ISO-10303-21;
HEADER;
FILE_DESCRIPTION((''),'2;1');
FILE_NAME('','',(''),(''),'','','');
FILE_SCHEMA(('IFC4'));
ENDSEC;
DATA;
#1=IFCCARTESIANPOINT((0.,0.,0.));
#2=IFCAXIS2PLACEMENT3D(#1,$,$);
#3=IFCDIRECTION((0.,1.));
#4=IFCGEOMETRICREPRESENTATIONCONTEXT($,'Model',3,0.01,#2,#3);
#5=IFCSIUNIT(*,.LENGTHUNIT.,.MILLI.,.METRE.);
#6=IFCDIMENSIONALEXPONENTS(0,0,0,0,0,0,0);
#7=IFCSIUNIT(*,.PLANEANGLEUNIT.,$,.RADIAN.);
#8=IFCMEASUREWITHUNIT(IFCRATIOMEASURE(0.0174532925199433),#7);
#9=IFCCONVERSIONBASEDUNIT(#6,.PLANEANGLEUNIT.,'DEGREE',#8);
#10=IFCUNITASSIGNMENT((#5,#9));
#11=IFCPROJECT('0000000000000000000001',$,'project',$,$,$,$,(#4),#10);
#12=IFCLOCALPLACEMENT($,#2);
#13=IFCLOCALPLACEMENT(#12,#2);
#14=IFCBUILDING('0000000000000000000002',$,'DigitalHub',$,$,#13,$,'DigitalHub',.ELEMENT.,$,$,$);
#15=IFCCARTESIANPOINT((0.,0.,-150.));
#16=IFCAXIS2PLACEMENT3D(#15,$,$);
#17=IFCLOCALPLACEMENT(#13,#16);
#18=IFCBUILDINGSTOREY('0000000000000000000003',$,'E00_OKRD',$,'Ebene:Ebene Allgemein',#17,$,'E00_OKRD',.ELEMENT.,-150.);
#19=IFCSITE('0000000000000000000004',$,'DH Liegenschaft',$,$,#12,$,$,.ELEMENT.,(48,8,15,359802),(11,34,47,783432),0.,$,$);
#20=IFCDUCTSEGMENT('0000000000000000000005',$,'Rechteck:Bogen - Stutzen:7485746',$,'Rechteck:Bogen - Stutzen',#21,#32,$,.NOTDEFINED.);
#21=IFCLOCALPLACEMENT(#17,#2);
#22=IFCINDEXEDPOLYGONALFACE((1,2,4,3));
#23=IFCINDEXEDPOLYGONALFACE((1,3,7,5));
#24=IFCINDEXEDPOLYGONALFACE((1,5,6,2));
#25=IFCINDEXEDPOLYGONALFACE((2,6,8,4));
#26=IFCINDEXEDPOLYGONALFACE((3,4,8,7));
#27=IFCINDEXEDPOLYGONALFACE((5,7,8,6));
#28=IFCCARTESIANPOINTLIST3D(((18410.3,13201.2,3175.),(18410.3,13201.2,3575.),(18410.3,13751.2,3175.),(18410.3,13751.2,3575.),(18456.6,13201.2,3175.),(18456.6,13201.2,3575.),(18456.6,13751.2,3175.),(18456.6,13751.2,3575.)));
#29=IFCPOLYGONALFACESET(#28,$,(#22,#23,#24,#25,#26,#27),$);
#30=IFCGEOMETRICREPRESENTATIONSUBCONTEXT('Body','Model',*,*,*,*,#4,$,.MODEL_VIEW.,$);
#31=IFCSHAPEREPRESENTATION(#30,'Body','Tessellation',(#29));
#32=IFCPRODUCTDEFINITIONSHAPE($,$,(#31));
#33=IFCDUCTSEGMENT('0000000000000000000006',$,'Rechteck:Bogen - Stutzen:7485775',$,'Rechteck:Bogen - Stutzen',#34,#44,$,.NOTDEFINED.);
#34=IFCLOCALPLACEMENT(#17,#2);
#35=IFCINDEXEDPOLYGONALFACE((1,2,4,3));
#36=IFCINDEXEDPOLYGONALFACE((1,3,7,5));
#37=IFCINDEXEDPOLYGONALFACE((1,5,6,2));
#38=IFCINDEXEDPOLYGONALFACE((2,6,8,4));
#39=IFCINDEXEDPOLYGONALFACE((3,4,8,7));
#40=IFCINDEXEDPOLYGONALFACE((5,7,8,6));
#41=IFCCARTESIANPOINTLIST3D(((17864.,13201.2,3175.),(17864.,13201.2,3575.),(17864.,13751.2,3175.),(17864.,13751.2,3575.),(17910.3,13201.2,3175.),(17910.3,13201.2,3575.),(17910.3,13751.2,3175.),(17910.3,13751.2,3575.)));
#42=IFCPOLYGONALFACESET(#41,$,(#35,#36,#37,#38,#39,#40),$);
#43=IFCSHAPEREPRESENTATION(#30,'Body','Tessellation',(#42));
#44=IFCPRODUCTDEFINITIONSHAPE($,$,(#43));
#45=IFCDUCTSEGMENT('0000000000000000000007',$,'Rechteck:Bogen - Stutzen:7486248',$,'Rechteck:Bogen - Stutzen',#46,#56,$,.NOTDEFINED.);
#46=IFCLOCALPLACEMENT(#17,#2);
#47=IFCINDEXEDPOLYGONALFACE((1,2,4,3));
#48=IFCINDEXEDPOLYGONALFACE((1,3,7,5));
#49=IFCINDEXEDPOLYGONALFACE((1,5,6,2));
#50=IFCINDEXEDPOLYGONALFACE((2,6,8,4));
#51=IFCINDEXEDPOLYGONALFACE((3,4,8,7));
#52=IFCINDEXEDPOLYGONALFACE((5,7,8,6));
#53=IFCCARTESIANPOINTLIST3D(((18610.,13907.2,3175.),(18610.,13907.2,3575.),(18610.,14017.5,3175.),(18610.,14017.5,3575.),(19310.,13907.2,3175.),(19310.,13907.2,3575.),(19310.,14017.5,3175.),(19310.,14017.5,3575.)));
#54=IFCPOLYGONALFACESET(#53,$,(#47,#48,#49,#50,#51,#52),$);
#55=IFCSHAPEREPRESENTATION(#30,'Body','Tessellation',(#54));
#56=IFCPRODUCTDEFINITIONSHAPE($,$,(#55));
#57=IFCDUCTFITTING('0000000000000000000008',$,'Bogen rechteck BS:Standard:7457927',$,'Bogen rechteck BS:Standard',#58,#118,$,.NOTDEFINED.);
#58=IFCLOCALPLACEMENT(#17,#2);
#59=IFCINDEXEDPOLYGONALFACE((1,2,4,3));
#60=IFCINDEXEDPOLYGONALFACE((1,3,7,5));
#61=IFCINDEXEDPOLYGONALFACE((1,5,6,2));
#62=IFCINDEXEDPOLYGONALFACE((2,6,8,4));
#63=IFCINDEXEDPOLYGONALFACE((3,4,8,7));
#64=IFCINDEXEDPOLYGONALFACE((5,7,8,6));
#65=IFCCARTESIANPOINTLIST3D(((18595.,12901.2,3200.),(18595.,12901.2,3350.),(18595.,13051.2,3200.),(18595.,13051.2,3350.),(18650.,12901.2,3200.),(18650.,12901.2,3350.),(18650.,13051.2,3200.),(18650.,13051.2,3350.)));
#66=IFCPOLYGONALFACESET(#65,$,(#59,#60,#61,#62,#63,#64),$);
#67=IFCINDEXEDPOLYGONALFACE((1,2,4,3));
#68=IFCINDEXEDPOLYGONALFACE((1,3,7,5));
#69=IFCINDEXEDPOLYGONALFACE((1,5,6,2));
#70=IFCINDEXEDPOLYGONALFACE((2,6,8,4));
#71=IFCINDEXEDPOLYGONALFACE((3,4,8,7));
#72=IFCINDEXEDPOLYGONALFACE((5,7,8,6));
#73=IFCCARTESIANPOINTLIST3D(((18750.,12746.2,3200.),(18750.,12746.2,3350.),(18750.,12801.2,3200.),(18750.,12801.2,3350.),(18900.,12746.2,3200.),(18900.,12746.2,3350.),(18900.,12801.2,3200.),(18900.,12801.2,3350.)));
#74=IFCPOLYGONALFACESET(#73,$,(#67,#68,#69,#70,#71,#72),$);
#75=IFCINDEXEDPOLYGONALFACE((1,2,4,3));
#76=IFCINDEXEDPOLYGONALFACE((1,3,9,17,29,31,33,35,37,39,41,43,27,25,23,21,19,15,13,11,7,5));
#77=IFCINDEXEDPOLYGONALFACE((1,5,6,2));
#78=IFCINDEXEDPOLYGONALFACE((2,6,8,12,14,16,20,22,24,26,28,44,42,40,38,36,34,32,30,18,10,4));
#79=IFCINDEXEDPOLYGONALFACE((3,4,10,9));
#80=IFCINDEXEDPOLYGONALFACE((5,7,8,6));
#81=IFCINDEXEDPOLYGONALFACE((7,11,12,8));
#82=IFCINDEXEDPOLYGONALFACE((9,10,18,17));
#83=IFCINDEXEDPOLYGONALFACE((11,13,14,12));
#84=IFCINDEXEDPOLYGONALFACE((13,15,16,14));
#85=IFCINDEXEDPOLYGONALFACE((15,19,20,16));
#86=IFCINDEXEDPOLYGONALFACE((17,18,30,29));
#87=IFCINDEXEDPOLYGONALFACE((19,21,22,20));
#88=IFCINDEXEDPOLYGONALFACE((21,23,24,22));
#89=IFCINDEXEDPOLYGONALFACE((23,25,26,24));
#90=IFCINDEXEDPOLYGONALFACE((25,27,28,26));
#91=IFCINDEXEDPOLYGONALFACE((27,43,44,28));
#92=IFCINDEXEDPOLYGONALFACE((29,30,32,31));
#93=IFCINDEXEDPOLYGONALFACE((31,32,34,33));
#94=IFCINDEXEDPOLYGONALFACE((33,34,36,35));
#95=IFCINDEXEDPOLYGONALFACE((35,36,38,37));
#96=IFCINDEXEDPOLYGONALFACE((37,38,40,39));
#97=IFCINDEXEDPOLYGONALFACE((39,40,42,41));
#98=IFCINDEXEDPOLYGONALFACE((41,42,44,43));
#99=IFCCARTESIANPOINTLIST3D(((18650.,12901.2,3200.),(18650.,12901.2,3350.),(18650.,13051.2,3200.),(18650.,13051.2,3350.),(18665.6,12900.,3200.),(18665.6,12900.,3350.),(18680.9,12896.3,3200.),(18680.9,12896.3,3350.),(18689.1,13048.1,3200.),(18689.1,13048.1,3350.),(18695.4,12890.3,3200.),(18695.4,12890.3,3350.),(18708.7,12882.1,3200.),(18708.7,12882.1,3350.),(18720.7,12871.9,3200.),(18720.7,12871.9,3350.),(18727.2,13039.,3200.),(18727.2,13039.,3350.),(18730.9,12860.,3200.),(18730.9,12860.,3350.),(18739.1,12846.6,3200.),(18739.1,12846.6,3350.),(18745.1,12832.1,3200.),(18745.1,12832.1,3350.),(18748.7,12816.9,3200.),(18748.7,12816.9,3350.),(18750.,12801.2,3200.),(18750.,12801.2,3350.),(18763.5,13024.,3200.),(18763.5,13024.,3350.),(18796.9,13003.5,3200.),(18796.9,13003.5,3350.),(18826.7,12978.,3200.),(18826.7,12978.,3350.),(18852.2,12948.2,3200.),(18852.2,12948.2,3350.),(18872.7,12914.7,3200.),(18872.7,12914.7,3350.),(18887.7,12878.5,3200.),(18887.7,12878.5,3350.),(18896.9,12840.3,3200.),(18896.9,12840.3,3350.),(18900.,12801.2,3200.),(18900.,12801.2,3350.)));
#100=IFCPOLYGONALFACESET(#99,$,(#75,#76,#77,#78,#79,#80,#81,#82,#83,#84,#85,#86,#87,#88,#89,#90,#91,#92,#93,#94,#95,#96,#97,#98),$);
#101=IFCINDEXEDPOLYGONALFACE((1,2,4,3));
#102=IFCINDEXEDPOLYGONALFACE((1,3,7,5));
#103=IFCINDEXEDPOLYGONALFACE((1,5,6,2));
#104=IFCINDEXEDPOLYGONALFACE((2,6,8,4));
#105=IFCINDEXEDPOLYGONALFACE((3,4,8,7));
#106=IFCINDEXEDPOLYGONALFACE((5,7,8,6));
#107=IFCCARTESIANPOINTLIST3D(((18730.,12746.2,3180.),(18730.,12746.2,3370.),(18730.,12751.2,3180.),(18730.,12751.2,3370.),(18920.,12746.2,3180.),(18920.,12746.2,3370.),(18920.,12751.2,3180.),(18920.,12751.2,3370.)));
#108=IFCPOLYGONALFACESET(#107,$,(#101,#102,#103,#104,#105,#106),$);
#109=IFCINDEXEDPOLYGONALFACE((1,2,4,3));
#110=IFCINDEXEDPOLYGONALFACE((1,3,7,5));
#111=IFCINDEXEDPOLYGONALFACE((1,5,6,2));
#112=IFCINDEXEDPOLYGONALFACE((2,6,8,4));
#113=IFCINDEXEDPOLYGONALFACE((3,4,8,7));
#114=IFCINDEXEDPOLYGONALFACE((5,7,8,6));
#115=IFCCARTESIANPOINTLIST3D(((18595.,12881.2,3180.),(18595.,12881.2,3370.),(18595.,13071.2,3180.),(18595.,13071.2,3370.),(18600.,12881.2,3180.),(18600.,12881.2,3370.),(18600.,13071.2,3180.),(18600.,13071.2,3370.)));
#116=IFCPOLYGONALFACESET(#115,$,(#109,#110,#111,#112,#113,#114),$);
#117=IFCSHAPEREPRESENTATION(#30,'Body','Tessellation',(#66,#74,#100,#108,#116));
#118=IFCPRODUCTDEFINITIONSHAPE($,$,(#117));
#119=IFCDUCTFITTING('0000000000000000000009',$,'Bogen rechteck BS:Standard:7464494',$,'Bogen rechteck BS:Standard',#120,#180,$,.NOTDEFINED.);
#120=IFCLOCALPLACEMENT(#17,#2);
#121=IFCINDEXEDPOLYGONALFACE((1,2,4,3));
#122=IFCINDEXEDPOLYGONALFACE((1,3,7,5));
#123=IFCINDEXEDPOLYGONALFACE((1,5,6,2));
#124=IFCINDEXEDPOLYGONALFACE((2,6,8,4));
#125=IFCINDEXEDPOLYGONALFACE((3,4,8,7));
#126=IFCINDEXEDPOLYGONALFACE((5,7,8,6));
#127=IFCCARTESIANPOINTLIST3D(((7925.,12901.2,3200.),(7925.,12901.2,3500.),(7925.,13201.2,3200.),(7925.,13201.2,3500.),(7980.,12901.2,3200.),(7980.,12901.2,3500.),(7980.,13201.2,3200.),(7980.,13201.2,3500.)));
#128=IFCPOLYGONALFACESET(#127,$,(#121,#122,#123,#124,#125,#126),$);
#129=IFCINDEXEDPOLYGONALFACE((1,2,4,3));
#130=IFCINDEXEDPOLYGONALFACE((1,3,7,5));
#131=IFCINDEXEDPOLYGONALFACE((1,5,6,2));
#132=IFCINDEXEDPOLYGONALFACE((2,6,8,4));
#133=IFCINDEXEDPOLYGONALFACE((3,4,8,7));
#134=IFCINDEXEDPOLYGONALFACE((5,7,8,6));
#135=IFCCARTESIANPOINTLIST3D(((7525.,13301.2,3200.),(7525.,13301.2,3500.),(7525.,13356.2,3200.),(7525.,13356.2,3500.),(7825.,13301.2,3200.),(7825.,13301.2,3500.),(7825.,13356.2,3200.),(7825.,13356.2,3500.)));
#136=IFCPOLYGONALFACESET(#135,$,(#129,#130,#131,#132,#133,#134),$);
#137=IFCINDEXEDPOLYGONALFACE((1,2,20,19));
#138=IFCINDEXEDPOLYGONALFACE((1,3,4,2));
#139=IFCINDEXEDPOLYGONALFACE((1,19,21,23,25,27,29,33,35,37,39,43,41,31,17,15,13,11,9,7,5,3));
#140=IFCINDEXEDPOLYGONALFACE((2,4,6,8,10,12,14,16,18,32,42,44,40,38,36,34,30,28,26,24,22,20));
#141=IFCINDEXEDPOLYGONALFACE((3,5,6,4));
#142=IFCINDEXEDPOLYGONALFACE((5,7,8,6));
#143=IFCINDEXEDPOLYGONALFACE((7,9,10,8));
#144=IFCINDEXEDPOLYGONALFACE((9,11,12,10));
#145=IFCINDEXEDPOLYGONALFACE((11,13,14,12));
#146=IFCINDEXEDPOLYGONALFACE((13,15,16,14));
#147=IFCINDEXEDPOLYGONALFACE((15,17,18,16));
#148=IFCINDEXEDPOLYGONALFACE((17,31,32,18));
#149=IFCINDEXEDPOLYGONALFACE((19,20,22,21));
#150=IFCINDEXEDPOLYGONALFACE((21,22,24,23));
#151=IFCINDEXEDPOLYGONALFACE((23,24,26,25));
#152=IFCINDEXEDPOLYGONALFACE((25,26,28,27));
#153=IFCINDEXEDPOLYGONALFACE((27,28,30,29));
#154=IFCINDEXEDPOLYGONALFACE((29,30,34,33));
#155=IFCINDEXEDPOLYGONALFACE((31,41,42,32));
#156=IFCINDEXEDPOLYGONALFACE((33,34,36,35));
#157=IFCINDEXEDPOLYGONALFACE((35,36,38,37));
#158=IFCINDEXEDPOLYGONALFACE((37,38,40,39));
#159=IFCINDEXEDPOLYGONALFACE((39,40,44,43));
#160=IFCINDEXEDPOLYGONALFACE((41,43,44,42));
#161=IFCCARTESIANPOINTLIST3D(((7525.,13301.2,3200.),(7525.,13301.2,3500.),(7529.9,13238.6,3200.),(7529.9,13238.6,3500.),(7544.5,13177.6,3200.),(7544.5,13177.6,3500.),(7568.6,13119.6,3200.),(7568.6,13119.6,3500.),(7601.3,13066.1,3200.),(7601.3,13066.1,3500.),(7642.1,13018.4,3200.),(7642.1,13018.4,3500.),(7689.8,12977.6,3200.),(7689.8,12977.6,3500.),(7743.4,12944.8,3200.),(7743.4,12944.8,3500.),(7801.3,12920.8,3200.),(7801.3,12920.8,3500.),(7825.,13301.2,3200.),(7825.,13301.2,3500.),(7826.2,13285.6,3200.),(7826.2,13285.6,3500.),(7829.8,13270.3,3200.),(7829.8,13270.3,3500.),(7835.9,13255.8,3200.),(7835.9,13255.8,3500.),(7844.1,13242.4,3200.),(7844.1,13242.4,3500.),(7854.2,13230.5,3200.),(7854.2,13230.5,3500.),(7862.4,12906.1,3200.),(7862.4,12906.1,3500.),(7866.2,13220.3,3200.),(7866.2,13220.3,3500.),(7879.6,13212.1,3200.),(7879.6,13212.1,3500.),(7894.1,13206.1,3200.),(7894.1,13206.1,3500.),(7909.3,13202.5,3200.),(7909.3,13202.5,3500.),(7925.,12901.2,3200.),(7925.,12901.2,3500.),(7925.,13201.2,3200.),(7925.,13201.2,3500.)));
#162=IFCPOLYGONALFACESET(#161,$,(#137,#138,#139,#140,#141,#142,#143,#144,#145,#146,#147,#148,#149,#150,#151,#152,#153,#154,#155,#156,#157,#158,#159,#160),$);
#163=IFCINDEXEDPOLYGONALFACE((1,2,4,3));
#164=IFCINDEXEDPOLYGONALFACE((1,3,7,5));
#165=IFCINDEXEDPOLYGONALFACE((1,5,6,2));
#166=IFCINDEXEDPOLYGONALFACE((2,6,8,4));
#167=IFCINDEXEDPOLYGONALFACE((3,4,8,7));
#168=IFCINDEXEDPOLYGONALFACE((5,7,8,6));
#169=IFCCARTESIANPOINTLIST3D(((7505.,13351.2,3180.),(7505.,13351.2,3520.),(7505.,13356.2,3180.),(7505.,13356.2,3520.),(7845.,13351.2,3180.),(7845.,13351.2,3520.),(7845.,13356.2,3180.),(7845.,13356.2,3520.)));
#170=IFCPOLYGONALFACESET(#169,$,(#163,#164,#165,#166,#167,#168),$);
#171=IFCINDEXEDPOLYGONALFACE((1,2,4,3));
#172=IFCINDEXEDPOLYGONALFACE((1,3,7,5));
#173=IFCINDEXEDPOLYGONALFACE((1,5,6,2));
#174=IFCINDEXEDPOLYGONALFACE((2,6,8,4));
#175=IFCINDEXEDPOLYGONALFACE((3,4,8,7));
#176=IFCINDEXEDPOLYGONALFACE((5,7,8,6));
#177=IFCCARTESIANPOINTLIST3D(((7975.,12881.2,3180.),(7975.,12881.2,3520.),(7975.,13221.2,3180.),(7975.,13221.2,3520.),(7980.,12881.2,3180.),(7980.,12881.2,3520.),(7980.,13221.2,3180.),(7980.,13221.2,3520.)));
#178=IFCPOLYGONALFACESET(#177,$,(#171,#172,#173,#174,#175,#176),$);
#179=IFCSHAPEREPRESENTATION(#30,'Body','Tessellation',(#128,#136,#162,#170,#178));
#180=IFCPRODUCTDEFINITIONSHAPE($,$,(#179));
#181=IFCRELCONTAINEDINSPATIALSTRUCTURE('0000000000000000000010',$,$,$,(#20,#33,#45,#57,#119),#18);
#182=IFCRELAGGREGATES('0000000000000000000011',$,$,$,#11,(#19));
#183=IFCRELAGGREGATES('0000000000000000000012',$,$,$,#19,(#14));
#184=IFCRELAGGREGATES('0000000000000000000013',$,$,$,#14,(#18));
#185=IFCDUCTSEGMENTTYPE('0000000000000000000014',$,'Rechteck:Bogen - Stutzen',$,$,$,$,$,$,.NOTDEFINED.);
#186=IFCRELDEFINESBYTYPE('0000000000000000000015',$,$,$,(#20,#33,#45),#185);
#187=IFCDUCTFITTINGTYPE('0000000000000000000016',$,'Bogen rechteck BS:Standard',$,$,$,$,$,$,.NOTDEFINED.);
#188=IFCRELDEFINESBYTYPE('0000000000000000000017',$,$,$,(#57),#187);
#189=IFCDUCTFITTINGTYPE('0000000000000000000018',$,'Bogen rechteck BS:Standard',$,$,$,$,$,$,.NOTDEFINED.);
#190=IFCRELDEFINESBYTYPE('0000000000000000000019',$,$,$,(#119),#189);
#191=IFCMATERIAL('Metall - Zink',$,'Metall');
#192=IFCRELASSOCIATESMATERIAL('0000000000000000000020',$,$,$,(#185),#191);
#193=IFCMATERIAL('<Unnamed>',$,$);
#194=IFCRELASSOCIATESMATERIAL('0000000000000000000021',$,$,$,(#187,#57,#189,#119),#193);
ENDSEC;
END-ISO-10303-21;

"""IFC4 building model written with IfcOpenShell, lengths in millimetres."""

from ifc_helpers import new_model, entity, si_unit, converted_unit, direction, frame, origin, place, context, subcontext, project, spatial, indexed_curve, outline, extrude, source, transform, mapped, material, type_object, type_shapes, element, save


model = new_model("IFC4")

# Units and contexts
model_context = context("Model", 3, precision=0.01, world=origin(), true_north=direction((0.0, 1.0)))
body_context = subcontext(model_context, "Body", "Model", "MODEL_VIEW")
ifc_project = project(units=[si_unit("LENGTHUNIT", "METRE", prefix="MILLI"), converted_unit("PLANEANGLEUNIT", "DEGREE", entity("IfcRatioMeasure", 0.0174532925199433), si_unit("PLANEANGLEUNIT", "RADIAN"), dimensions=[0, 0, 0, 0, 0, 0, 0])], contexts=[model_context])

# Site, building, storey
site_placement = place(None, origin())
site = spatial("IfcSite", under=ifc_project, at=site_placement, Name="DH Liegenschaft", CompositionType="ELEMENT", RefLatitude=(48, 8, 15, 359802), RefLongitude=(11, 34, 47, 783432), RefElevation=0.0)
building_placement = place(site_placement, origin())
building = spatial("IfcBuilding", under=site, at=building_placement, Name="DigitalHub", LongName="DigitalHub", CompositionType="ELEMENT")
storey_placement = place(building_placement, frame((0.0, 0.0, -150.0)))
storey = spatial("IfcBuildingStorey", under=building, at=storey_placement, Name="E00_OKRD", ObjectType="Ebene:Ebene Allgemein", LongName="E00_OKRD", CompositionType="ELEMENT", Elevation=-150.0)

# Duct segments
ifc_material_1 = material(Name="Metall - Zink", Category="Metall")
duct_segment_type = type_object("IfcDuctSegmentType", Name="Rechteck:Bogen - Stutzen", PredefinedType="NOTDEFINED", material=ifc_material_1)
duct_segment_1_placement = place(storey_placement, frame((18410.3, 13201.2, 3175.0)))
element("IfcDuctSegment", 1, at=duct_segment_1_placement, inside=storey, type_object=duct_segment_type, Name="Rechteck:Bogen - Stutzen:7485746", ObjectType="Rechteck:Bogen - Stutzen", PredefinedType="NOTDEFINED", context=body_context, shape_type="SweptSolid", body=[
    extrude(outline(indexed_curve([(-23.1, -275.0), (23.1, -275.0), (23.1, 275.0), (-23.1, 275.0), (-23.1, -275.0)], self_intersect=False)), frame((23.1, 275.0, 0.0)), (0.0, 0.0, 1.0), 400.0),
])
duct_segment_2_placement = place(storey_placement, frame((17864.0, 13201.2, 3175.0)))
element("IfcDuctSegment", 2, at=duct_segment_2_placement, inside=storey, type_object=duct_segment_type, Name="Rechteck:Bogen - Stutzen:7485775", ObjectType="Rechteck:Bogen - Stutzen", PredefinedType="NOTDEFINED", context=body_context, shape_type="SweptSolid", body=[
    extrude(outline(indexed_curve([(-23.1, -275.0), (23.1, -275.0), (23.1, 275.0), (-23.1, 275.0), (-23.1, -275.0)], self_intersect=False)), frame((23.1, 275.0, 0.0)), (0.0, 0.0, 1.0), 400.0),
])
duct_segment_3_placement = place(storey_placement, frame((18610.0, 13907.2, 3175.0)))
element("IfcDuctSegment", 3, at=duct_segment_3_placement, inside=storey, type_object=duct_segment_type, Name="Rechteck:Bogen - Stutzen:7486248", ObjectType="Rechteck:Bogen - Stutzen", PredefinedType="NOTDEFINED", context=body_context, shape_type="SweptSolid", body=[
    extrude(outline(indexed_curve([(-55.2, -350.0), (55.2, -350.0), (55.2, 350.0), (-55.2, 350.0), (-55.2, -350.0)], self_intersect=False)), frame((350.0, 55.2, 0.0), z_axis=(0.0, 0.0, 1.0), x_axis=(0.0, -1.0, 0.0)), (0.0, 0.0, 1.0), 400.0),
])

# Duct fittings
ifc_material_2 = material(Name="<Unnamed>")
duct_fitting_type_1 = type_object("IfcDuctFittingType", Name="Bogen rechteck BS:Standard", PredefinedType="NOTDEFINED", material=ifc_material_2)
shared_shape_1 = source(origin(), body_context, "Body", "SweptSolid", [
    extrude(outline(indexed_curve([(-27.5, -75.0), (27.5, -75.0), (27.5, 75.0), (-27.5, 75.0), (-27.5, -75.0)], self_intersect=False)), frame((0.0, 202.5, -75.0), z_axis=(0.0, 0.0, 1.0), x_axis=(0.0, 1.0, 0.0)), (0.0, 0.0, 1.0), 150.0),
    extrude(outline(indexed_curve([(-75.0, -27.5), (75.0, -27.5), (75.0, 27.5), (-75.0, 27.5), (-75.0, -27.5)], self_intersect=False)), frame((-202.5, 0.0, -75.0), z_axis=(0.0, 0.0, 1.0), x_axis=(0.0, -1.0, 0.0)), (0.0, 0.0, 1.0), 150.0),
    extrude(outline(indexed_curve([(-162.5, -87.5), (-12.5, -87.5), (-11.3, -71.9), (-7.6, -56.6), (-1.6, -42.1), (6.6, -28.7), (16.8, -16.8), (28.7, -6.6), (42.1, 1.6), (56.6, 7.6), (71.9, 11.3), (87.5, 12.5), (87.5, 162.5), (48.4, 159.4), (10.2, 150.3), (-26.0, 135.3), (-59.4, 114.8), (-89.3, 89.3), (-114.8, 59.4), (-135.3, 26.0), (-150.3, -10.2), (-159.4, -48.4), (-162.5, -87.5)], self_intersect=False)), frame((-87.5, 87.5, -75.0), z_axis=(0.0, 0.0, 1.0), x_axis=(-1.0, 0.0, 0.0)), (0.0, 0.0, 1.0), 150.0),
    extrude(outline(indexed_curve([(-2.5, -95.0), (2.5, -95.0), (2.5, 95.0), (-2.5, 95.0), (-2.5, -95.0)], self_intersect=False)), frame((-227.5, 0.0, -95.0)), (0.0, 0.0, 1.0), 190.0),
    extrude(outline(indexed_curve([(-2.5, -95.0), (2.5, -95.0), (2.5, 95.0), (-2.5, 95.0), (-2.5, -95.0)], self_intersect=False)), frame((0.0, 227.5, -95.0), z_axis=(0.0, 0.0, 1.0), x_axis=(0.0, 1.0, 0.0)), (0.0, 0.0, 1.0), 190.0),
])
type_shapes(duct_fitting_type_1, [shared_shape_1])
duct_fitting_1_placement = place(storey_placement, frame((18825.0, 12976.2, 3275.0), z_axis=(0.0, 0.0, 1.0), x_axis=(0.0, 1.0, 0.0)))
element("IfcDuctFitting", 4, at=duct_fitting_1_placement, inside=storey, type_object=duct_fitting_type_1, material=ifc_material_2, Name="Bogen rechteck BS:Standard:7457927", ObjectType="Bogen rechteck BS:Standard", PredefinedType="NOTDEFINED", context=body_context, shape_type="MappedRepresentation", body=[
    mapped(shared_shape_1, transform((0.0, 0.0, 0.0), scale=1.0)),
])
duct_fitting_type_2 = type_object("IfcDuctFittingType", Name="Bogen rechteck BS:Standard", PredefinedType="NOTDEFINED", material=ifc_material_2)
shared_shape_2 = source(origin(), body_context, "Body", "SweptSolid", [
    extrude(outline(indexed_curve([(-27.5, -150.0), (27.5, -150.0), (27.5, 150.0), (-27.5, 150.0), (-27.5, -150.0)], self_intersect=False)), frame((0.0, 277.5, -150.0), z_axis=(0.0, 0.0, 1.0), x_axis=(0.0, 1.0, 0.0)), (0.0, 0.0, 1.0), 300.0),
    extrude(outline(indexed_curve([(-150.0, -27.5), (150.0, -27.5), (150.0, 27.5), (-150.0, 27.5), (-150.0, -27.5)], self_intersect=False)), frame((-277.5, 0.0, -150.0), z_axis=(0.0, 0.0, 1.0), x_axis=(0.0, -1.0, 0.0)), (0.0, 0.0, 1.0), 300.0),
    extrude(outline(indexed_curve([(-275.0, -125.0), (25.0, -125.0), (26.2, -109.4), (29.9, -94.1), (35.9, -79.6), (44.1, -66.2), (54.3, -54.3), (66.2, -44.1), (79.6, -35.9), (94.1, -29.9), (109.4, -26.2), (125.0, -25.0), (125.0, 275.0), (62.4, 270.1), (1.4, 255.4), (-56.6, 231.4), (-110.1, 198.6), (-157.8, 157.8), (-198.6, 110.1), (-231.4, 56.6), (-255.4, -1.4), (-270.1, -62.4), (-275.0, -125.0)], self_intersect=False)), frame((-125.0, 125.0, -150.0), z_axis=(0.0, 0.0, 1.0), x_axis=(-1.0, 0.0, 0.0)), (0.0, 0.0, 1.0), 300.0),
    extrude(outline(indexed_curve([(-2.5, -170.0), (2.5, -170.0), (2.5, 170.0), (-2.5, 170.0), (-2.5, -170.0)], self_intersect=False)), frame((-302.5, 0.0, -170.0)), (0.0, 0.0, 1.0), 340.0),
    extrude(outline(indexed_curve([(-2.5, -170.0), (2.5, -170.0), (2.5, 170.0), (-2.5, 170.0), (-2.5, -170.0)], self_intersect=False)), frame((0.0, 302.5, -170.0), z_axis=(0.0, 0.0, 1.0), x_axis=(0.0, 1.0, 0.0)), (0.0, 0.0, 1.0), 340.0),
])
type_shapes(duct_fitting_type_2, [shared_shape_2])
duct_fitting_2_placement = place(storey_placement, frame((7675.0, 13051.2, 3350.0), z_axis=(0.0, 0.0, 1.0), x_axis=(0.0, -1.0, 0.0)))
element("IfcDuctFitting", 5, at=duct_fitting_2_placement, inside=storey, type_object=duct_fitting_type_2, material=ifc_material_2, Name="Bogen rechteck BS:Standard:7464494", ObjectType="Bogen rechteck BS:Standard", PredefinedType="NOTDEFINED", context=body_context, shape_type="MappedRepresentation", body=[
    mapped(shared_shape_2, transform((0.0, 0.0, 0.0), scale=1.0)),
])

save(model, "model.ifc")
